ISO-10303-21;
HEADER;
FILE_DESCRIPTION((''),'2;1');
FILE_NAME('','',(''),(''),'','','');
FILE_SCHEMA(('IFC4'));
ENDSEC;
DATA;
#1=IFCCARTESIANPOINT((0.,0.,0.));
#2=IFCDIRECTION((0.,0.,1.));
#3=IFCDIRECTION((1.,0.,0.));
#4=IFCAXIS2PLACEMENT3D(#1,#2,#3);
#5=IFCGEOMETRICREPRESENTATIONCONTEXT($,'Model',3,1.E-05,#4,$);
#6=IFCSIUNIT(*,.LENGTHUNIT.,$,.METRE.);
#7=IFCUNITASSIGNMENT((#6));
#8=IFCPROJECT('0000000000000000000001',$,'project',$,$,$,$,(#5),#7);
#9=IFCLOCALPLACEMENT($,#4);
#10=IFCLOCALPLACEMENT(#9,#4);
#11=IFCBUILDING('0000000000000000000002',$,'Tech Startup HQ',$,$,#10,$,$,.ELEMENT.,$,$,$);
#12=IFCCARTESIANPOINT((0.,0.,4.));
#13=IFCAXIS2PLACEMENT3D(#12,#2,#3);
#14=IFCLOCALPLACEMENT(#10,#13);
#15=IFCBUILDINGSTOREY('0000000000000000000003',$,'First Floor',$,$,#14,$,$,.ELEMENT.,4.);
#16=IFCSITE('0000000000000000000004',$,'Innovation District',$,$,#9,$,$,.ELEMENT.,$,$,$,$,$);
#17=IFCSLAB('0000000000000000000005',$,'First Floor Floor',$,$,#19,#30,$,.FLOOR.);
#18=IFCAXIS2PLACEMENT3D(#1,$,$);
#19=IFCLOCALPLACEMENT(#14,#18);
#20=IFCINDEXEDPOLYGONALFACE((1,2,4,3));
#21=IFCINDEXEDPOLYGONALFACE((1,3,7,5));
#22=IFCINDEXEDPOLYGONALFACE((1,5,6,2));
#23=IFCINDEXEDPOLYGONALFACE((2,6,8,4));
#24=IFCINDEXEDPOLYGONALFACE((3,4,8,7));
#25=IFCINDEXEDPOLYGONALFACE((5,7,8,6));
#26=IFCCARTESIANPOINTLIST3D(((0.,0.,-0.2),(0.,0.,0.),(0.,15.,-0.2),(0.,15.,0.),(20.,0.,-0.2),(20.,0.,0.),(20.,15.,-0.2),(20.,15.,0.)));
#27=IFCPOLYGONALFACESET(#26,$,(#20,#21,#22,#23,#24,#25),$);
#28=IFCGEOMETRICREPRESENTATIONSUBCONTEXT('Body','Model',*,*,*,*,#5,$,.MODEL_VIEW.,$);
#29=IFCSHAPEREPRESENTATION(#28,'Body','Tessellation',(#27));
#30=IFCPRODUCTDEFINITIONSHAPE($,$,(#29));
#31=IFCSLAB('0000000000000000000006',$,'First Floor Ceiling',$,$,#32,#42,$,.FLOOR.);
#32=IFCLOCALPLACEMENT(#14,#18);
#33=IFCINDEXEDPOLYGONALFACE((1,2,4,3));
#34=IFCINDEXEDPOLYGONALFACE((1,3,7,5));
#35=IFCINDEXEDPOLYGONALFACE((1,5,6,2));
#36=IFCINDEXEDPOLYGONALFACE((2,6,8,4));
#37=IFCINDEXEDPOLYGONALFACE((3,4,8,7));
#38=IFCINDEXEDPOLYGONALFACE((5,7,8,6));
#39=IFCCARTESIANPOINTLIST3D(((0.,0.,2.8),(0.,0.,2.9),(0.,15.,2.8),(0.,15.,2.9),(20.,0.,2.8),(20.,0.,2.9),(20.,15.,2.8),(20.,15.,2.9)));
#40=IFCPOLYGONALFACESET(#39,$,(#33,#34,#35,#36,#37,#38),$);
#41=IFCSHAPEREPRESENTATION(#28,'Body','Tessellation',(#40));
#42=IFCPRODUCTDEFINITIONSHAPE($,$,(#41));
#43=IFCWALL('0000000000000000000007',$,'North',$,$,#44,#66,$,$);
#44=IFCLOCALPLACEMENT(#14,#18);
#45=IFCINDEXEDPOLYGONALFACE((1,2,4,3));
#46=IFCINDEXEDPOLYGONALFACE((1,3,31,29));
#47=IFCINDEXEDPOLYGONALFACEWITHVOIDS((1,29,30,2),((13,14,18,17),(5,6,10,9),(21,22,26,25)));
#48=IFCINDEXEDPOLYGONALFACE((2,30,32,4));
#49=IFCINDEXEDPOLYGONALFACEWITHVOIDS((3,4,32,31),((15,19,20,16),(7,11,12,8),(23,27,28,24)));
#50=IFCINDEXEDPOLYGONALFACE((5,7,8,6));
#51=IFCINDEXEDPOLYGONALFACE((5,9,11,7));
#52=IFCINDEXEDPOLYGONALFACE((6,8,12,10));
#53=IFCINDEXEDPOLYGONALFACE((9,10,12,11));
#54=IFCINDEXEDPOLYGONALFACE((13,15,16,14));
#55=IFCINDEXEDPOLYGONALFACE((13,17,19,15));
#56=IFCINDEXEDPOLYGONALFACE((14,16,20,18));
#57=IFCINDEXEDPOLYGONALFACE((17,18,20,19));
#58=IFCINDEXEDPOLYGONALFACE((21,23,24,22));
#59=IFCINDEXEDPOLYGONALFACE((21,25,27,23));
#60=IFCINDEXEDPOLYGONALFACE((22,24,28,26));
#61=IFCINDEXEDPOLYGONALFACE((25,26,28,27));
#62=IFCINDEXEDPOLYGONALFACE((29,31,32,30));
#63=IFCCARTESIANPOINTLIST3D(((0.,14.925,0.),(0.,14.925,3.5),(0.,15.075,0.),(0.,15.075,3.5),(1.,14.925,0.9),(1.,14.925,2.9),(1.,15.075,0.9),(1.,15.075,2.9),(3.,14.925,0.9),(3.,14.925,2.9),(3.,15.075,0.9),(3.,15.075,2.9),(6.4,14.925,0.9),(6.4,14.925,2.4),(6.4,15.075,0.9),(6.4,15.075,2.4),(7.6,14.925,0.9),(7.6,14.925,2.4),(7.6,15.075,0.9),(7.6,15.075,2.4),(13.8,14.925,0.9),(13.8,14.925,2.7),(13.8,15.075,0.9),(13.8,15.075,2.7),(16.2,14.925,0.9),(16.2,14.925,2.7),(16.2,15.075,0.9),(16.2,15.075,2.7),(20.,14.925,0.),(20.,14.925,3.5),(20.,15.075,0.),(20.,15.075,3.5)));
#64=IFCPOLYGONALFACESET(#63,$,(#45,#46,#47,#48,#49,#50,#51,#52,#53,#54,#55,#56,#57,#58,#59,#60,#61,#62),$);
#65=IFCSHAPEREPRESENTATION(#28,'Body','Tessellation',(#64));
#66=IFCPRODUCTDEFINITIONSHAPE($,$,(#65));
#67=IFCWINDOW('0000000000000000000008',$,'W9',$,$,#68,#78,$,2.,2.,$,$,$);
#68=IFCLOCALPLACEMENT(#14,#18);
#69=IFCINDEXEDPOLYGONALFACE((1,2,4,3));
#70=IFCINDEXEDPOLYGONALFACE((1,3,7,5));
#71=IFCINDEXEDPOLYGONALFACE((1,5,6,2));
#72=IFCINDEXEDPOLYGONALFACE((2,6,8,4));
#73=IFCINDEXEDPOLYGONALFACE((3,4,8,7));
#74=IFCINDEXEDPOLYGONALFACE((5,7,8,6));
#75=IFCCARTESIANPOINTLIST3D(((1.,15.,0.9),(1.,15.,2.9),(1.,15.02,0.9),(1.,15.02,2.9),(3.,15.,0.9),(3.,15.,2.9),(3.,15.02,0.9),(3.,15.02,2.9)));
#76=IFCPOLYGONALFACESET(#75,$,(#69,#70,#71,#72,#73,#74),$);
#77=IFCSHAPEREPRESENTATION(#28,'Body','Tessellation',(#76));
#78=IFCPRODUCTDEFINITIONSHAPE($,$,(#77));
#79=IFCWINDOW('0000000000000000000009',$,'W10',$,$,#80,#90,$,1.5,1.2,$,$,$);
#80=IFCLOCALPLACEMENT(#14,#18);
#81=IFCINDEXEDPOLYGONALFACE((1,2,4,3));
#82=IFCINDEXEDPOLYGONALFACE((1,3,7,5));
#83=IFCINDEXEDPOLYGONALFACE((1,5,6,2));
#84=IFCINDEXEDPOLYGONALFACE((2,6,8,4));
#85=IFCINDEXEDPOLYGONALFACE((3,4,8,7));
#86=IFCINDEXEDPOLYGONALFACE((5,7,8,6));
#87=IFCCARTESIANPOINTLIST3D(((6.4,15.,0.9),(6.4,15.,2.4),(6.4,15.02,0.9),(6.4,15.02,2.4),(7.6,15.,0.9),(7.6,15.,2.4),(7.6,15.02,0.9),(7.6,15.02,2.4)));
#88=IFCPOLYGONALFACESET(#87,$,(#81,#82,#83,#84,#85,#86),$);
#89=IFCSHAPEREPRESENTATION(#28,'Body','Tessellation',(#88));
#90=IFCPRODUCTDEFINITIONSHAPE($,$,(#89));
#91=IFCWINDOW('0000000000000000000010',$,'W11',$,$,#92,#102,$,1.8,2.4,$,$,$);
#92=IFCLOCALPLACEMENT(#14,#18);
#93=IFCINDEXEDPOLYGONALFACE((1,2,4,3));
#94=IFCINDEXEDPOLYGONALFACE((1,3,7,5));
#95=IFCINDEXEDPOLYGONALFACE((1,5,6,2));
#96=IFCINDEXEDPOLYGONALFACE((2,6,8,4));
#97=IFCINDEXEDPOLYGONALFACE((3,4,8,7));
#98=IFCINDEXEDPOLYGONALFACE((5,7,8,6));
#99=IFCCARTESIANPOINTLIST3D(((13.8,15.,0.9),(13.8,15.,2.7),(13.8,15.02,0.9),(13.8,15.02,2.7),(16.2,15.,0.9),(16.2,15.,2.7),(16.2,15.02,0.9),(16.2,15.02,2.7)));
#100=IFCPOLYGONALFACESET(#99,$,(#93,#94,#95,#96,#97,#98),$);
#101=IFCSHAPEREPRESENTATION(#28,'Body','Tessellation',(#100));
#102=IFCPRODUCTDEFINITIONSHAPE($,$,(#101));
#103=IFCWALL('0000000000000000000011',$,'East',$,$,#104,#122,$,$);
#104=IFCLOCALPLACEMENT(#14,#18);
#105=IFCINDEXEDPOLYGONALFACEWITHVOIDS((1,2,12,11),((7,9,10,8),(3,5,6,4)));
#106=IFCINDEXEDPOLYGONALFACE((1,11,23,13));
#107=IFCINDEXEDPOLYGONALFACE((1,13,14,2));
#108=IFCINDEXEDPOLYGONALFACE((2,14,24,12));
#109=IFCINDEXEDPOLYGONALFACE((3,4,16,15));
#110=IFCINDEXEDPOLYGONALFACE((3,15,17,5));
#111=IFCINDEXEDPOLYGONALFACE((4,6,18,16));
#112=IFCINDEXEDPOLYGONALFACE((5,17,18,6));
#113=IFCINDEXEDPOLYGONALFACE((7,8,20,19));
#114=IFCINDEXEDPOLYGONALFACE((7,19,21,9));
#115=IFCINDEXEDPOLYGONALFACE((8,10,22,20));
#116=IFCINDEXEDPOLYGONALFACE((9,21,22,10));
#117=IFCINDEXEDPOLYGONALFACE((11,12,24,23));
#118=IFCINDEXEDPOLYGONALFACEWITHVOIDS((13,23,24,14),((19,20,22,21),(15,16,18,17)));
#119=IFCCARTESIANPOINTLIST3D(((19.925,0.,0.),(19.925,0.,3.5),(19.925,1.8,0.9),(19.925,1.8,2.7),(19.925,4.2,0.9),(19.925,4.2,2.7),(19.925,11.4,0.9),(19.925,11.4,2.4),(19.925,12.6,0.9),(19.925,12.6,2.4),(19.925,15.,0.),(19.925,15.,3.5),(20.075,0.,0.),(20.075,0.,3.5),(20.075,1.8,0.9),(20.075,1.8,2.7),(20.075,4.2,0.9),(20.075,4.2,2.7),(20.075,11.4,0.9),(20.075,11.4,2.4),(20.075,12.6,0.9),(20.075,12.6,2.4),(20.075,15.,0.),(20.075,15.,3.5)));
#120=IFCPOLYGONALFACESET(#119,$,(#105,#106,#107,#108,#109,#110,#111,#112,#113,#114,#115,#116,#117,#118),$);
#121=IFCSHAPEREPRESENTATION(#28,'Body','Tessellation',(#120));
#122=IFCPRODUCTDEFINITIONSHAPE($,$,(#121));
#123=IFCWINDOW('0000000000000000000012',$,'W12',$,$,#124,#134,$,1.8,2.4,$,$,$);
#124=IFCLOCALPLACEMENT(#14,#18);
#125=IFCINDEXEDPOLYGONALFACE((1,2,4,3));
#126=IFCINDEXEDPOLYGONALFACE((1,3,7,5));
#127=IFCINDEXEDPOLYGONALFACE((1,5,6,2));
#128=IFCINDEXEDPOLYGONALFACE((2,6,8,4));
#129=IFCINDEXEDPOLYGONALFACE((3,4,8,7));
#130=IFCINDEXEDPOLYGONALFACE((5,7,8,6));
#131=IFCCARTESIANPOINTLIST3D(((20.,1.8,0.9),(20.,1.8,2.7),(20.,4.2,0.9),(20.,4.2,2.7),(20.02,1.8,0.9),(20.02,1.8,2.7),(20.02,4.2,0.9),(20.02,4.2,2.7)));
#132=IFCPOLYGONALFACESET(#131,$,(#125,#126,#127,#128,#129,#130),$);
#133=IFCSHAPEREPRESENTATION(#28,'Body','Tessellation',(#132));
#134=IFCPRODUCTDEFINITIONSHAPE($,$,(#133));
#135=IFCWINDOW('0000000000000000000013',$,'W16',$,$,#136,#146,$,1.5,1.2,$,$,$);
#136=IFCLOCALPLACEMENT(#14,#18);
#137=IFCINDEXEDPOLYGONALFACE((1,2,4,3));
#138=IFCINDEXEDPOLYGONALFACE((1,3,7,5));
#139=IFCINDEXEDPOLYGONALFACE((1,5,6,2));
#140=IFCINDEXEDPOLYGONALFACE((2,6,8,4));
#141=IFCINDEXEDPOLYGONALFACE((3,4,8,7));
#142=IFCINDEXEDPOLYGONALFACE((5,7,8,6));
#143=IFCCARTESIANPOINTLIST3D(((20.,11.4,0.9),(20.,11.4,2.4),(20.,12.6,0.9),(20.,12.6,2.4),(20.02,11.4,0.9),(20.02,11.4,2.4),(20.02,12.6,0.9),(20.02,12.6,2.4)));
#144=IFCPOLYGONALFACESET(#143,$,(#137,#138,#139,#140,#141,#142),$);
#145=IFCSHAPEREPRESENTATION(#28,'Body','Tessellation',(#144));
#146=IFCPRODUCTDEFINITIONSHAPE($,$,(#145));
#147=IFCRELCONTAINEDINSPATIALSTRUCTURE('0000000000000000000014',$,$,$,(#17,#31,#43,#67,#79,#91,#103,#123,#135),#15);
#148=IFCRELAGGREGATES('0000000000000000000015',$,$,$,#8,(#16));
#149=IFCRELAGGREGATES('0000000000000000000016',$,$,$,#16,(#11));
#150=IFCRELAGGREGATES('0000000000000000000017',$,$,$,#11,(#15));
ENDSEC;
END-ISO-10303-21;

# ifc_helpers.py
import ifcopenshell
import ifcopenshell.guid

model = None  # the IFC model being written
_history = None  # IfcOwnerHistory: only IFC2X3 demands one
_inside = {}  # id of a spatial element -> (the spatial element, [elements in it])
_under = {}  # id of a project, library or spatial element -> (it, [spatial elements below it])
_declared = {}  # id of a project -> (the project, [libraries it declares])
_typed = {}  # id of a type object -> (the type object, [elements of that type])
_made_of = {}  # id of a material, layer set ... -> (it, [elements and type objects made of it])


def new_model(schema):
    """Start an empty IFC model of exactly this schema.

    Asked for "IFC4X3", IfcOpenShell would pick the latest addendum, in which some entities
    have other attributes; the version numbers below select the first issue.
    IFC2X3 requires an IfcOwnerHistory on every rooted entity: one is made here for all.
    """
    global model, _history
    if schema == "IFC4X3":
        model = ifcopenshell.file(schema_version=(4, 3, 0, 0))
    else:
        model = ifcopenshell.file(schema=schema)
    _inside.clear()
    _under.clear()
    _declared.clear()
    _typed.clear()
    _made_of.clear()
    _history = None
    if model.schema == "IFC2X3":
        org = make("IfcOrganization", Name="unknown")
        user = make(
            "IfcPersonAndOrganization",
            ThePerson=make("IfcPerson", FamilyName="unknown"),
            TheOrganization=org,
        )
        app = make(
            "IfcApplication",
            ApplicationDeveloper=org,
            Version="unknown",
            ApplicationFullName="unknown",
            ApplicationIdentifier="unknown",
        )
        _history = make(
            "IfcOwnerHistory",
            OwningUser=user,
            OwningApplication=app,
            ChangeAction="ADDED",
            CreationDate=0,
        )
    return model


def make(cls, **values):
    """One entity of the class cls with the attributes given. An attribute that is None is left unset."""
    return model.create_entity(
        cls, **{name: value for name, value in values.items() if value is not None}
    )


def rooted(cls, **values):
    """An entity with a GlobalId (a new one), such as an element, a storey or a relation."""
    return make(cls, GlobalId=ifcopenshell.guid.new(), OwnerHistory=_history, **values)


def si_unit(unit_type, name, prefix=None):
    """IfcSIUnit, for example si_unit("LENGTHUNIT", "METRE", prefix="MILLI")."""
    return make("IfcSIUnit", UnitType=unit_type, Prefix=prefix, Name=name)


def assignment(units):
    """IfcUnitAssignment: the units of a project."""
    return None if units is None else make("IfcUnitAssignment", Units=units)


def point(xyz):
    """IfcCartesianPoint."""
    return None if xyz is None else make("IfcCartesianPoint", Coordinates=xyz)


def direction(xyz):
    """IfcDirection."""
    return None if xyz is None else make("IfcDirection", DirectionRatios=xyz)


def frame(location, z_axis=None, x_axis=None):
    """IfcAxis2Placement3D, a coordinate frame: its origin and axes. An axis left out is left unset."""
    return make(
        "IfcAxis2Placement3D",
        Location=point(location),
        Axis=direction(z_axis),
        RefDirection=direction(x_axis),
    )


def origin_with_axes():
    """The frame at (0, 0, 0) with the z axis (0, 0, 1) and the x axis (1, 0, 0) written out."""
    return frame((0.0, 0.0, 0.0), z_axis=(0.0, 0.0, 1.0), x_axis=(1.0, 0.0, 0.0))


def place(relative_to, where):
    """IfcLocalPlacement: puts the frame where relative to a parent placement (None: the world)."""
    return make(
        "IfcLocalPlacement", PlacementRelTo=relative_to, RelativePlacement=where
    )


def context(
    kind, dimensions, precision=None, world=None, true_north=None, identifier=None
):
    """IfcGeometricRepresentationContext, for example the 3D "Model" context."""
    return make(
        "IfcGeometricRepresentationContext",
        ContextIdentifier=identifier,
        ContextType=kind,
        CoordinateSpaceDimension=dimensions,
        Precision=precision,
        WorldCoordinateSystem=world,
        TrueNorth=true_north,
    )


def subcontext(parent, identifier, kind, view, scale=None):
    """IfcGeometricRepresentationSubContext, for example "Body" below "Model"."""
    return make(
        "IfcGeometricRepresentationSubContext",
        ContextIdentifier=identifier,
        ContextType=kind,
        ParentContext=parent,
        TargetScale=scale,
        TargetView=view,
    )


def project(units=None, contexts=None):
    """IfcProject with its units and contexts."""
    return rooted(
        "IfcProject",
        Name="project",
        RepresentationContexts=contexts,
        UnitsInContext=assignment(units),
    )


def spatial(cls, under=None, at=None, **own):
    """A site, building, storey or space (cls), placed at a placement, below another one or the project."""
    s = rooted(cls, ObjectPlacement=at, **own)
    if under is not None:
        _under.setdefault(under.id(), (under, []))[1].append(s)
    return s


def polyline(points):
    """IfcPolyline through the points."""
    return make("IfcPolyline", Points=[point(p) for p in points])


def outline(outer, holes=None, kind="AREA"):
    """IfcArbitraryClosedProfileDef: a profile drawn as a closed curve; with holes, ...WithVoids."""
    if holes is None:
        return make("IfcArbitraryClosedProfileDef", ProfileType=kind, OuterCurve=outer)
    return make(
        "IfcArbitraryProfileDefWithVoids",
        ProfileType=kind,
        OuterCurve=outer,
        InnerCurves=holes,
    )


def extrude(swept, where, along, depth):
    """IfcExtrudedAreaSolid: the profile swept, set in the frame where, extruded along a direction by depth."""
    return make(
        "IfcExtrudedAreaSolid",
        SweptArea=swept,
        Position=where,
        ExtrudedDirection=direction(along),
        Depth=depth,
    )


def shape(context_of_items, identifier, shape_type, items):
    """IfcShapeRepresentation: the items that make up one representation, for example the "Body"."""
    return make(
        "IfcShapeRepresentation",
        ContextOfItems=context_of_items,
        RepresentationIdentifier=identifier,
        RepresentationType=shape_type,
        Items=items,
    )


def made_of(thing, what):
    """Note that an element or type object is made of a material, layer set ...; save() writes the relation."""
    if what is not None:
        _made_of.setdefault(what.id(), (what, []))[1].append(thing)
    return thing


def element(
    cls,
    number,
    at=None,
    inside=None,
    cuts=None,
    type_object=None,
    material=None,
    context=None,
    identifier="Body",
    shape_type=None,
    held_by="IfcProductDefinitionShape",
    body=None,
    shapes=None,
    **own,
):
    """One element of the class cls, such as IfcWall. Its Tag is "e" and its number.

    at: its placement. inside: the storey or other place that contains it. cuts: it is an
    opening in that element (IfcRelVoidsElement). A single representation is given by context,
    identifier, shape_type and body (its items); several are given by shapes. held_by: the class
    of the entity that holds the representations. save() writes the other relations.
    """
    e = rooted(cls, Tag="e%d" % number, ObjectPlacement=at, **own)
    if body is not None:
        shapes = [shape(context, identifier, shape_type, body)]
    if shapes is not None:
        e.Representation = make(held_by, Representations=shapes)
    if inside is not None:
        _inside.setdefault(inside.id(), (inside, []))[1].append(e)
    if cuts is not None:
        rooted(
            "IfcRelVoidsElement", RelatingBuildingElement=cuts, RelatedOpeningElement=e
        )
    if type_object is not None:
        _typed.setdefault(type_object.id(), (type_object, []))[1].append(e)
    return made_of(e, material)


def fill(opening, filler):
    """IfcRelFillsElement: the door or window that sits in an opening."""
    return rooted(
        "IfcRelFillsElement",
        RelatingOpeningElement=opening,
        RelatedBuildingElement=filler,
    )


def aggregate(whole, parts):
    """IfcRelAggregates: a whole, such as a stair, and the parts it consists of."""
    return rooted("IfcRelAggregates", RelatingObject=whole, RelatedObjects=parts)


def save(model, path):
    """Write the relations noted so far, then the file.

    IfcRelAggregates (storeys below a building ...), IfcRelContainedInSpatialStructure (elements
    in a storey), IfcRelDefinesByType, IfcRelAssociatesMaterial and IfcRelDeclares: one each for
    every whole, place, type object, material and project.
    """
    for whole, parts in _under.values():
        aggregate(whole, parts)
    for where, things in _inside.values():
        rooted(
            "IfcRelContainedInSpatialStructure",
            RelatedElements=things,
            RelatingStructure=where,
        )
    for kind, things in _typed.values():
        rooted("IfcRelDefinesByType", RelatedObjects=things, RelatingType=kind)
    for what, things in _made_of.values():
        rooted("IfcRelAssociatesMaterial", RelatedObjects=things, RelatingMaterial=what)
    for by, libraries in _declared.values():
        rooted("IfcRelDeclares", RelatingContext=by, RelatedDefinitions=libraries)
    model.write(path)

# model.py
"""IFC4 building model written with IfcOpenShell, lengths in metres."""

from ifc_helpers import new_model, si_unit, frame, origin_with_axes, place, context, subcontext, project, spatial, polyline, outline, extrude, element, fill, save


model = new_model("IFC4")

# Units and contexts
model_context = context("Model", 3, precision=1e-05, world=origin_with_axes())
body_context = subcontext(model_context, "Body", "Model", "MODEL_VIEW")
ifc_project = project(units=[si_unit("LENGTHUNIT", "METRE")], contexts=[model_context])

# Site, building, storey
site_placement = place(None, origin_with_axes())
site = spatial("IfcSite", under=ifc_project, at=site_placement, Name="Innovation District", CompositionType="ELEMENT")
building_placement = place(site_placement, origin_with_axes())
building = spatial("IfcBuilding", under=site, at=building_placement, Name="Tech Startup HQ", CompositionType="ELEMENT")
storey_placement = place(building_placement, frame((0.0, 0.0, 4.0), z_axis=(0.0, 0.0, 1.0), x_axis=(1.0, 0.0, 0.0)))
storey = spatial("IfcBuildingStorey", under=building, at=storey_placement, Name="First Floor", CompositionType="ELEMENT", Elevation=4.0)

# Slabs
slab_1_placement = place(storey_placement, origin_with_axes())
element("IfcSlab", 1, at=slab_1_placement, inside=storey, Name="First Floor Floor", PredefinedType="FLOOR", context=body_context, shape_type="SweptSolid", body=[
    extrude(outline(polyline([(0.0, 0.0, -0.2), (20.0, 0.0, -0.2), (20.0, 15.0, -0.2), (0.0, 15.0, -0.2), (0.0, 0.0, -0.2)])), None, (0.0, 0.0, 1.0), 0.2),
])
slab_2_placement = place(storey_placement, origin_with_axes())
element("IfcSlab", 2, at=slab_2_placement, inside=storey, Name="First Floor Ceiling", PredefinedType="FLOOR", context=body_context, shape_type="SweptSolid", body=[
    extrude(outline(polyline([(0.0, 0.0, 2.8), (20.0, 0.0, 2.8), (20.0, 15.0, 2.8), (0.0, 15.0, 2.8), (0.0, 0.0, 2.8)])), None, (0.0, 0.0, 1.0), 0.1),
])

# Walls, openings, windows
wall_1_placement = place(storey_placement, origin_with_axes())
wall_1 = element("IfcWall", 3, at=wall_1_placement, inside=storey, Name="North", context=body_context, shape_type="SweptSolid", body=[
    extrude(outline(polyline([(0.0, 14.925, 0.0), (20.0, 14.925, 0.0), (20.0, 15.075, 0.0), (0.0, 15.075, 0.0), (0.0, 14.925, 0.0)])), None, (0.0, 0.0, 1.0), 3.5),
])
opening_1_placement = place(storey_placement, origin_with_axes())
opening_1 = element("IfcOpeningElement", 4, at=opening_1_placement, inside=storey, cuts=wall_1, context=body_context, shape_type="SweptSolid", body=[
    extrude(outline(polyline([(1.0, 14.85, 0.9), (3.0, 14.85, 0.9), (3.0, 15.15, 0.9), (1.0, 15.15, 0.9), (1.0, 14.85, 0.9)])), None, (0.0, 0.0, 1.0), 2.0),
])
opening_2_placement = place(storey_placement, origin_with_axes())
opening_2 = element("IfcOpeningElement", 5, at=opening_2_placement, inside=storey, cuts=wall_1, context=body_context, shape_type="SweptSolid", body=[
    extrude(outline(polyline([(6.4, 14.85, 0.9), (7.6, 14.85, 0.9), (7.6, 15.15, 0.9), (6.4, 15.15, 0.9), (6.4, 14.85, 0.9)])), None, (0.0, 0.0, 1.0), 1.5),
])
opening_3_placement = place(storey_placement, origin_with_axes())
opening_3 = element("IfcOpeningElement", 6, at=opening_3_placement, inside=storey, cuts=wall_1, context=body_context, shape_type="SweptSolid", body=[
    extrude(outline(polyline([(13.8, 14.85, 0.9), (16.2, 14.85, 0.9), (16.2, 15.15, 0.9), (13.8, 15.15, 0.9), (13.8, 14.85, 0.9)])), None, (0.0, 0.0, 1.0), 1.8),
])
window_1_placement = place(storey_placement, origin_with_axes())
window_1 = element("IfcWindow", 7, at=window_1_placement, inside=storey, Name="W9", OverallHeight=2.0, OverallWidth=2.0, context=body_context, shape_type="SweptSolid", body=[
    extrude(outline(polyline([(1.0, 15.0, 0.9), (3.0, 15.0, 0.9), (3.0, 15.02, 0.9), (1.0, 15.02, 0.9), (1.0, 15.0, 0.9)])), None, (0.0, 0.0, 1.0), 2.0),
])
fill(opening_1, window_1)
window_2_placement = place(storey_placement, origin_with_axes())
window_2 = element("IfcWindow", 8, at=window_2_placement, inside=storey, Name="W10", OverallHeight=1.5, OverallWidth=1.2, context=body_context, shape_type="SweptSolid", body=[
    extrude(outline(polyline([(6.4, 15.0, 0.9), (7.6, 15.0, 0.9), (7.6, 15.02, 0.9), (6.4, 15.02, 0.9), (6.4, 15.0, 0.9)])), None, (0.0, 0.0, 1.0), 1.5),
])
fill(opening_2, window_2)
window_3_placement = place(storey_placement, origin_with_axes())
window_3 = element("IfcWindow", 9, at=window_3_placement, inside=storey, Name="W11", OverallHeight=1.8, OverallWidth=2.4, context=body_context, shape_type="SweptSolid", body=[
    extrude(outline(polyline([(13.8, 15.0, 0.9), (16.2, 15.0, 0.9), (16.2, 15.02, 0.9), (13.8, 15.02, 0.9), (13.8, 15.0, 0.9)])), None, (0.0, 0.0, 1.0), 1.8),
])
fill(opening_3, window_3)
wall_2_placement = place(storey_placement, origin_with_axes())
wall_2 = element("IfcWall", 10, at=wall_2_placement, inside=storey, Name="East", context=body_context, shape_type="SweptSolid", body=[
    extrude(outline(polyline([(19.925, 15.0, 0.0), (19.925, 0.0, 0.0), (20.075, 0.0, 0.0), (20.075, 15.0, 0.0), (19.925, 15.0, 0.0)])), None, (0.0, 0.0, 1.0), 3.5),
])
opening_4_placement = place(storey_placement, origin_with_axes())
opening_4 = element("IfcOpeningElement", 11, at=opening_4_placement, inside=storey, cuts=wall_2, context=body_context, shape_type="SweptSolid", body=[
    extrude(outline(polyline([(19.85, 4.2, 0.9), (19.85, 1.8, 0.9), (20.15, 1.8, 0.9), (20.15, 4.2, 0.9), (19.85, 4.2, 0.9)])), None, (0.0, 0.0, 1.0), 1.8),
])
opening_5_placement = place(storey_placement, origin_with_axes())
opening_5 = element("IfcOpeningElement", 12, at=opening_5_placement, inside=storey, cuts=wall_2, context=body_context, shape_type="SweptSolid", body=[
    extrude(outline(polyline([(19.85, 12.6, 0.9), (19.85, 11.4, 0.9), (20.15, 11.4, 0.9), (20.15, 12.6, 0.9), (19.85, 12.6, 0.9)])), None, (0.0, 0.0, 1.0), 1.5),
])
window_4_placement = place(storey_placement, origin_with_axes())
window_4 = element("IfcWindow", 13, at=window_4_placement, inside=storey, Name="W12", OverallHeight=1.8, OverallWidth=2.4, context=body_context, shape_type="SweptSolid", body=[
    extrude(outline(polyline([(20.0, 4.2, 0.9), (20.0, 1.8, 0.9), (20.02, 1.8, 0.9), (20.02, 4.2, 0.9), (20.0, 4.2, 0.9)])), None, (0.0, 0.0, 1.0), 1.8),
])
fill(opening_4, window_4)
window_5_placement = place(storey_placement, origin_with_axes())
window_5 = element("IfcWindow", 14, at=window_5_placement, inside=storey, Name="W16", OverallHeight=1.5, OverallWidth=1.2, context=body_context, shape_type="SweptSolid", body=[
    extrude(outline(polyline([(20.0, 12.6, 0.9), (20.0, 11.4, 0.9), (20.02, 11.4, 0.9), (20.02, 12.6, 0.9), (20.0, 12.6, 0.9)])), None, (0.0, 0.0, 1.0), 1.5),
])
fill(opening_5, window_5)

save(model, "model.ifc")
